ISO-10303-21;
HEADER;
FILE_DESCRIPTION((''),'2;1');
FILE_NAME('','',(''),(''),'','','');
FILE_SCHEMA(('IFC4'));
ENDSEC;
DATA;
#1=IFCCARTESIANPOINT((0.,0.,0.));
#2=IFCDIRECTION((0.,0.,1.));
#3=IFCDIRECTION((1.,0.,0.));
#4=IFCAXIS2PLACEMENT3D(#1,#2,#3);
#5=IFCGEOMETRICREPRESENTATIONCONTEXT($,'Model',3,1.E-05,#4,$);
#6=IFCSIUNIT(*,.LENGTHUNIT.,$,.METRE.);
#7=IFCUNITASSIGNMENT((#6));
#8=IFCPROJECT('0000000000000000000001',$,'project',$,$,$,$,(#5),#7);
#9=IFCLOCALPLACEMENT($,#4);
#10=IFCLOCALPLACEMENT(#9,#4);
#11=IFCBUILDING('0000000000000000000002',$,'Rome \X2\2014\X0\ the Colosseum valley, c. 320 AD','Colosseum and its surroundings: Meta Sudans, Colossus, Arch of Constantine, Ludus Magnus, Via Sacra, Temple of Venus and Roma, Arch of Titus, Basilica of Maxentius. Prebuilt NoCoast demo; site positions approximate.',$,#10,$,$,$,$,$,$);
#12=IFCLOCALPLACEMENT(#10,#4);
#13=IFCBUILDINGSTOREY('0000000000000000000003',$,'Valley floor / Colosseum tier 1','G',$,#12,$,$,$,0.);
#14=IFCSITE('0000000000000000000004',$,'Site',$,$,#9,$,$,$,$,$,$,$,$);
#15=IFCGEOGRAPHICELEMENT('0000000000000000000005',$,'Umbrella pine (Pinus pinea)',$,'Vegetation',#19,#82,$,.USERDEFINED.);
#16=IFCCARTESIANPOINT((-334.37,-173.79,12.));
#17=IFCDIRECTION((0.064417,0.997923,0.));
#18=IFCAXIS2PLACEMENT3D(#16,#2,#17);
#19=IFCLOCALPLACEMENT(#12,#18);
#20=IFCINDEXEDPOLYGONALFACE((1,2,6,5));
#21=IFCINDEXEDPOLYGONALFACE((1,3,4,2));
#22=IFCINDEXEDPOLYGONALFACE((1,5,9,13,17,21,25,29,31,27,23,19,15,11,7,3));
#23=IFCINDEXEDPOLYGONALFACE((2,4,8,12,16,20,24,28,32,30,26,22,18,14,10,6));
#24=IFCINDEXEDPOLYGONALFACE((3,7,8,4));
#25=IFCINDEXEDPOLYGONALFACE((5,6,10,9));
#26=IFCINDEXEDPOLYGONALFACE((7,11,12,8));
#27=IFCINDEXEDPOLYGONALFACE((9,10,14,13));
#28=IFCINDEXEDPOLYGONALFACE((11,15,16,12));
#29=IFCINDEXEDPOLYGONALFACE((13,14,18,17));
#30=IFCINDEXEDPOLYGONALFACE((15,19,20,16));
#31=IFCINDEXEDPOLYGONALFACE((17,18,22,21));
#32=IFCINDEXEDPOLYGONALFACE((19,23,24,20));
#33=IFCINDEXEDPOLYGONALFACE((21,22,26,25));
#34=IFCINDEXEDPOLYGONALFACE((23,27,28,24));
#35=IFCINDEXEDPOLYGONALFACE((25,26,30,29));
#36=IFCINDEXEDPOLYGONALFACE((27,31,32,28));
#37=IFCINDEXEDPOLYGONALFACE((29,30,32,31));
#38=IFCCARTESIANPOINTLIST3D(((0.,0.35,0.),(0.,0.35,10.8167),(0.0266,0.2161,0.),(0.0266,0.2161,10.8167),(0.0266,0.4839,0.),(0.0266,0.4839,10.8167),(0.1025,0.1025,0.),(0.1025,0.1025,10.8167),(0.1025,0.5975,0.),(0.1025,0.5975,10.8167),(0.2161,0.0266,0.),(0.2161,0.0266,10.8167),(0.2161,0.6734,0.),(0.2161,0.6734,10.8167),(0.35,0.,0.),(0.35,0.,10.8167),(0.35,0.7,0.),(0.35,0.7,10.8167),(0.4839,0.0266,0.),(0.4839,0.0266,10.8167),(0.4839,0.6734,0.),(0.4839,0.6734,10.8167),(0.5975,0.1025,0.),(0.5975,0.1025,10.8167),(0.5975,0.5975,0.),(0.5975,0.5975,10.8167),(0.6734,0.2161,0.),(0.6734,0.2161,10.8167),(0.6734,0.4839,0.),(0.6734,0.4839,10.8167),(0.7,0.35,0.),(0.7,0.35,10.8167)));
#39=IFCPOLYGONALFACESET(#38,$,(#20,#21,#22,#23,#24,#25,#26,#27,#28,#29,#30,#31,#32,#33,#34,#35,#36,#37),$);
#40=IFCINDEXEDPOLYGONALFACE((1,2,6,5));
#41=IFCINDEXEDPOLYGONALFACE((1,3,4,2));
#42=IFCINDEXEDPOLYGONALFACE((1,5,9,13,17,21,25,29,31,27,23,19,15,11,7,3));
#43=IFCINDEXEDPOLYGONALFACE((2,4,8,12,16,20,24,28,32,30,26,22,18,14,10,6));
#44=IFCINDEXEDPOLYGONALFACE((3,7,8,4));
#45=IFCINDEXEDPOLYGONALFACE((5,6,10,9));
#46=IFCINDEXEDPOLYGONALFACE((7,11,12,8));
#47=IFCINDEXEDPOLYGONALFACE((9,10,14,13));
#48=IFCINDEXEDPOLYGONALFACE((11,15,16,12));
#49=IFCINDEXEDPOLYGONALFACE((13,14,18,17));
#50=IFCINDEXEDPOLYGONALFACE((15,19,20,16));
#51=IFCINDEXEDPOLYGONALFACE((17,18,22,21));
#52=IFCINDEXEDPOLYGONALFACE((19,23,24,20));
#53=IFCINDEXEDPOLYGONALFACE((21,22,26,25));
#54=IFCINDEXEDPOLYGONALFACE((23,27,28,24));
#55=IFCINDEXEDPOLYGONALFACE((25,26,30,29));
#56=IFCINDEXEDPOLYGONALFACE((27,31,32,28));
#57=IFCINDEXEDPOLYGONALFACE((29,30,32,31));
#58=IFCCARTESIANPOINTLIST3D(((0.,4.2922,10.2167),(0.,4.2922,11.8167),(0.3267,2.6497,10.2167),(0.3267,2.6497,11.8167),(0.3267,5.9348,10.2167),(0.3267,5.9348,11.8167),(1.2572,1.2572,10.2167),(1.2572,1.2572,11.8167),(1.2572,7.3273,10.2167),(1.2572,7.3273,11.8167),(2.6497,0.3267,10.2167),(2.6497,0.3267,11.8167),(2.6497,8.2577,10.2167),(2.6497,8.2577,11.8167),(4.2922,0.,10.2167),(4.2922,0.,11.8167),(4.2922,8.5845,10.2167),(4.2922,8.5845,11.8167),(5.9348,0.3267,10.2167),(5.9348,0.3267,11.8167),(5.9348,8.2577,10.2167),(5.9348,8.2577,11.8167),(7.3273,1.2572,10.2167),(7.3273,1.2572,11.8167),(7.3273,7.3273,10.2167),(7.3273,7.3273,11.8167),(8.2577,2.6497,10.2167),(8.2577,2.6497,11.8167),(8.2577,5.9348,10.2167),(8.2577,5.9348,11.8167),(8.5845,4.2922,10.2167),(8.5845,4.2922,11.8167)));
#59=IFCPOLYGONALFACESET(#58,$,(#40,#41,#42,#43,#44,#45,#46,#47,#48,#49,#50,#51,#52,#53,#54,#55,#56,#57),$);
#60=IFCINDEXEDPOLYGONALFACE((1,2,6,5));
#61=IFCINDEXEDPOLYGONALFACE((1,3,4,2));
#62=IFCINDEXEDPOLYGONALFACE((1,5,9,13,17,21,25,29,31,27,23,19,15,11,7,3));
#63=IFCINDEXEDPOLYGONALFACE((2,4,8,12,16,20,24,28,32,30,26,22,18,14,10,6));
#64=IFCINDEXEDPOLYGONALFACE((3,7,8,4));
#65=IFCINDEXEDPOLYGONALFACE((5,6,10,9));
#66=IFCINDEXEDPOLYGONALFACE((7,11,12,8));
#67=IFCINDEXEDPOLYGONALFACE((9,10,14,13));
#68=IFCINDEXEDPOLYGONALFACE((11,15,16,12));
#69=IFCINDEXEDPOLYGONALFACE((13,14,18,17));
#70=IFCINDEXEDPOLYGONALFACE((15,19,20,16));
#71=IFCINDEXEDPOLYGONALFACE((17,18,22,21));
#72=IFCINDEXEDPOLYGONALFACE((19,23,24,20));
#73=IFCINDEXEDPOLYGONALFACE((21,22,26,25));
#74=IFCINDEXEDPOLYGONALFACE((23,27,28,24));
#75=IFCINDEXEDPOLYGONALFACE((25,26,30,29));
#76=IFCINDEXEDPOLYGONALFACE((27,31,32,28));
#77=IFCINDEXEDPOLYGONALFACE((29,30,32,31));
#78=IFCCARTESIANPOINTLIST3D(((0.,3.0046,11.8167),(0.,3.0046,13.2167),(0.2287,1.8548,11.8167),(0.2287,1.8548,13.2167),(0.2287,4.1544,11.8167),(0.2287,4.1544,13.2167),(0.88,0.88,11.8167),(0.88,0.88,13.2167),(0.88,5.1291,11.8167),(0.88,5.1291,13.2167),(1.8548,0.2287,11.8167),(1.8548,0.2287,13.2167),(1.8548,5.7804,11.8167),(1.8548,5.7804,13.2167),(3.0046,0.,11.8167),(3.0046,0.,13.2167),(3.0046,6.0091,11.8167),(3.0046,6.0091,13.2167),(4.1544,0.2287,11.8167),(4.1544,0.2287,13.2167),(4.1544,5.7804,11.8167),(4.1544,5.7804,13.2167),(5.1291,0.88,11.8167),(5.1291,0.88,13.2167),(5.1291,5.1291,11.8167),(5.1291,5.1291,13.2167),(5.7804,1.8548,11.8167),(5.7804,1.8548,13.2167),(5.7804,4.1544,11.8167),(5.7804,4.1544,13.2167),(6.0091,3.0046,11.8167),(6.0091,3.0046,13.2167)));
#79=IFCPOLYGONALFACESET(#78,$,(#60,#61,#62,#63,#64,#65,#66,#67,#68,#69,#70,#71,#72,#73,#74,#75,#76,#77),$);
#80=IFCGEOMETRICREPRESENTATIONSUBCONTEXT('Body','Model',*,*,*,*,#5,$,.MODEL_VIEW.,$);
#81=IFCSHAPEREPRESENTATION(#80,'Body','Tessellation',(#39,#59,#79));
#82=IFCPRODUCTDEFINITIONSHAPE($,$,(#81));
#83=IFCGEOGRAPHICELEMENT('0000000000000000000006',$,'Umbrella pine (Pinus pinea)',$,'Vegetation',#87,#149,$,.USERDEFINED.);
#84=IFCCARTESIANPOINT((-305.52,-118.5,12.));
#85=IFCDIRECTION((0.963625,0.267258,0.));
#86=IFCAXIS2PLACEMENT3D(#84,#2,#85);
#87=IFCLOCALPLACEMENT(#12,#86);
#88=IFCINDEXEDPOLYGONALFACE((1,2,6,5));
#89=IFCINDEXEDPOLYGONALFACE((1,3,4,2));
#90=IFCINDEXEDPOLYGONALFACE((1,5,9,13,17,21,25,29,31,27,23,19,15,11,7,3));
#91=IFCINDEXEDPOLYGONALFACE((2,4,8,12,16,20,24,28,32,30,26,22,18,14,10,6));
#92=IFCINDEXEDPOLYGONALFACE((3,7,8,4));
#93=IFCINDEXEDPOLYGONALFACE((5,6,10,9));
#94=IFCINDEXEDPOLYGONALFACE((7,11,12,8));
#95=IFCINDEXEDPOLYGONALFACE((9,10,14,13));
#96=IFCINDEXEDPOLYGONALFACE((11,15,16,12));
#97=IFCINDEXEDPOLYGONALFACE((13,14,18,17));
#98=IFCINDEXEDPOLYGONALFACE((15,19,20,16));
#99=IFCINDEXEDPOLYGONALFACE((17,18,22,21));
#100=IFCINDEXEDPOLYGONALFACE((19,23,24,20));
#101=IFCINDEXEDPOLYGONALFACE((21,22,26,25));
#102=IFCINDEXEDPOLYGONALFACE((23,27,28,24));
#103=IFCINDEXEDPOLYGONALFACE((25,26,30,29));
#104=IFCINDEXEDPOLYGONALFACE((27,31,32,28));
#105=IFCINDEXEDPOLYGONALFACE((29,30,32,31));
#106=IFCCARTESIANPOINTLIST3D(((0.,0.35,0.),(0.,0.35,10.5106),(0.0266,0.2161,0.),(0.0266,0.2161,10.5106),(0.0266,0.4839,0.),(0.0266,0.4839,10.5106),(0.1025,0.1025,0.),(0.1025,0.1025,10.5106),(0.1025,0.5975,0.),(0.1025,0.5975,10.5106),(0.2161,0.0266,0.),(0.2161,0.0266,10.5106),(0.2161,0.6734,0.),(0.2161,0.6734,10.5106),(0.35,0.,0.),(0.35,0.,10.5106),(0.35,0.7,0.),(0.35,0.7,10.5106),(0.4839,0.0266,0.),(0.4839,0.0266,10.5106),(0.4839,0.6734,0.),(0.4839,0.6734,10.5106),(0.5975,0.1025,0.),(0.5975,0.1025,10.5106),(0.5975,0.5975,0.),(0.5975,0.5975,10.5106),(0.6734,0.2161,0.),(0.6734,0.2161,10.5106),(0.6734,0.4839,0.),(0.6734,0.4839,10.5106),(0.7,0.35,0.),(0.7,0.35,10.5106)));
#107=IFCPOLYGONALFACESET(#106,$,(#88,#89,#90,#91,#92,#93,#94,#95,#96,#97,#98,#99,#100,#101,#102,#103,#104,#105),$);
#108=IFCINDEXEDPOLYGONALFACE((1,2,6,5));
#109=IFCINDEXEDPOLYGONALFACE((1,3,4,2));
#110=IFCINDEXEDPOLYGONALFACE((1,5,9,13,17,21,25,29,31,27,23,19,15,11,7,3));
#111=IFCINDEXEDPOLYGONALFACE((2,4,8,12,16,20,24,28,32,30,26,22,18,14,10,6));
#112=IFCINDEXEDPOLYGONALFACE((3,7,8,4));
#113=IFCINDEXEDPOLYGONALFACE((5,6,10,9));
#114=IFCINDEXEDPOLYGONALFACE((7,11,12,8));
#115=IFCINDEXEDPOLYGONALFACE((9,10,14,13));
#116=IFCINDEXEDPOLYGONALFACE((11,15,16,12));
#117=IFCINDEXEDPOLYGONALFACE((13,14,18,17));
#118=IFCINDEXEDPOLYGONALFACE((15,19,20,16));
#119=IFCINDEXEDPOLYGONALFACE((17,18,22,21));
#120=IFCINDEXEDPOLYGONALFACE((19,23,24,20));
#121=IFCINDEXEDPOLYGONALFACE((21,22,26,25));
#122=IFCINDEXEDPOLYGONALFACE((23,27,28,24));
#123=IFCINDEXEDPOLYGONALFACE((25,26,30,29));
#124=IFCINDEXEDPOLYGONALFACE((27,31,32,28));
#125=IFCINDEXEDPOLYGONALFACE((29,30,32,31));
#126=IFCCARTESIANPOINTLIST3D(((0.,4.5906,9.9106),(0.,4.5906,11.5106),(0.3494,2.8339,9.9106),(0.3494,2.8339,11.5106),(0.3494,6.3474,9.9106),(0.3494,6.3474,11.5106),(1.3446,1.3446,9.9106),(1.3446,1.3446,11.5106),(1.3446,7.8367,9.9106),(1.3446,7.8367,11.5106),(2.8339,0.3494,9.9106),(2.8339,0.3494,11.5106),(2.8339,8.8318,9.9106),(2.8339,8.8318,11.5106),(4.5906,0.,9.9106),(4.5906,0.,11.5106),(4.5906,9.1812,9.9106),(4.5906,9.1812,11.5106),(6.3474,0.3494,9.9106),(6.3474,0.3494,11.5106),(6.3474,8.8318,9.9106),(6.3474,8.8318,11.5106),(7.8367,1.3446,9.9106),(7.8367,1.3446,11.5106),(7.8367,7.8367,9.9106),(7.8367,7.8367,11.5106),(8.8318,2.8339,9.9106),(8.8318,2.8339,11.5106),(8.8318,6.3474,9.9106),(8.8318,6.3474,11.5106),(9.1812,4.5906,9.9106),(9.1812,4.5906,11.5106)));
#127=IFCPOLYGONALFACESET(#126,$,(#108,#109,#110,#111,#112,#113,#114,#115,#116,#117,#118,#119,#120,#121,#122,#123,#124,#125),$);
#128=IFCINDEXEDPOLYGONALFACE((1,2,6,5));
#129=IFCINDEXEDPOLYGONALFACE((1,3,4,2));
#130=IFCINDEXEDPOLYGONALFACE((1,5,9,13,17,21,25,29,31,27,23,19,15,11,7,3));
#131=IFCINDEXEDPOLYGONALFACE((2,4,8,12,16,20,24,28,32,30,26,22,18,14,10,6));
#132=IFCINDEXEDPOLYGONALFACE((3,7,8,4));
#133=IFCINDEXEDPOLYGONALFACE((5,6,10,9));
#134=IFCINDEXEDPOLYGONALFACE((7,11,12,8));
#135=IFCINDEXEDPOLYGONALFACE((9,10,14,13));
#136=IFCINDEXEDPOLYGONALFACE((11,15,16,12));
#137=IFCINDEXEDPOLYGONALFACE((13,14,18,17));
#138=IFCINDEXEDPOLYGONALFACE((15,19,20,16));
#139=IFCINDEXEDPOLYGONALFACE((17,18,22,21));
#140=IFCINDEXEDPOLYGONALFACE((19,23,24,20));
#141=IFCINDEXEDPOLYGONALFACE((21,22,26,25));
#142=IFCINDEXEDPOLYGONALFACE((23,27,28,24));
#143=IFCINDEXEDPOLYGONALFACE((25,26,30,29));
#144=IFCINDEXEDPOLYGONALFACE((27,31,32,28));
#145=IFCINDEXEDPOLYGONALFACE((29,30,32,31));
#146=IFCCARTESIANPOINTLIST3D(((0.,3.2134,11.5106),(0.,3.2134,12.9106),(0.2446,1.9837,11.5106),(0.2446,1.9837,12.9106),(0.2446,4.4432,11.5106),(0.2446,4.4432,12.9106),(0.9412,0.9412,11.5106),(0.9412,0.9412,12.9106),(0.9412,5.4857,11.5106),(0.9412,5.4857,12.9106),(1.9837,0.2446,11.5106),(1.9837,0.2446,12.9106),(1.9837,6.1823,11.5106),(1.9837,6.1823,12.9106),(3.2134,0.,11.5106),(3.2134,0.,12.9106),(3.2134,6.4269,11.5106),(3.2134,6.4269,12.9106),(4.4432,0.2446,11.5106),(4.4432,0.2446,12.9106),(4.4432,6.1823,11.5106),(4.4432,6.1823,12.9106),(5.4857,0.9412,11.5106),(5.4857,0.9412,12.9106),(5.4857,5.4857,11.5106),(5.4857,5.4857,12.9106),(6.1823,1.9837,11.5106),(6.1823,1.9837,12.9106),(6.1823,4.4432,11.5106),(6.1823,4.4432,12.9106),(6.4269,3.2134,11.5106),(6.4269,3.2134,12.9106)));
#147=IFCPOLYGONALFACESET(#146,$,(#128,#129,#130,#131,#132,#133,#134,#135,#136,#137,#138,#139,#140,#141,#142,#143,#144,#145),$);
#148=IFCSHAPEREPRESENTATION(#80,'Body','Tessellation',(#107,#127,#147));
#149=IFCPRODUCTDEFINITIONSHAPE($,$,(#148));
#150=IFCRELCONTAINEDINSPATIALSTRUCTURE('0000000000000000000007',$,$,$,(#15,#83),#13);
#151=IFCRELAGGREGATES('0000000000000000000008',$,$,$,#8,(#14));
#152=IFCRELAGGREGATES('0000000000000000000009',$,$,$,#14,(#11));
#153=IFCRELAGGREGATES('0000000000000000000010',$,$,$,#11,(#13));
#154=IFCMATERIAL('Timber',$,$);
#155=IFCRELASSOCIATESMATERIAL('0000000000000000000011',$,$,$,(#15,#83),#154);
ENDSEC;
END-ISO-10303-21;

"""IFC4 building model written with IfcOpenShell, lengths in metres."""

from ifc_helpers import new_model, si_unit, frame, origin_with_axes, place, context, subcontext, project, spatial, polyline, outline, extrude, material, element, save


model = new_model("IFC4")

# Units and contexts
model_context = context("Model", 3, precision=1e-05, world=origin_with_axes())
body_context = subcontext(model_context, "Body", "Model", "MODEL_VIEW")
ifc_project = project(units=[si_unit("LENGTHUNIT", "METRE")], contexts=[model_context])

# Site, building, storey
site_placement = place(None, origin_with_axes())
site = spatial("IfcSite", under=ifc_project, at=site_placement, Name="Site")
building_placement = place(site_placement, origin_with_axes())
building = spatial("IfcBuilding", under=site, at=building_placement, Name="Rome — the Colosseum valley, c. 320 AD", Description="Colosseum and its surroundings: Meta Sudans, Colossus, Arch of Constantine, Ludus Magnus, Via Sacra, Temple of Venus and Roma, Arch of Titus, Basilica of Maxentius. Prebuilt NoCoast demo; site positions approximate.")
storey_placement = place(building_placement, origin_with_axes())
storey = spatial("IfcBuildingStorey", under=building, at=storey_placement, Name="Valley floor / Colosseum tier 1", Description="G", Elevation=0.0)

# Shared definitions
ifc_material_1 = material(Name="Timber")

# Geographic elements
geographic_element_1_placement = place(storey_placement, frame((-334.37, -173.79, 12.0), z_axis=(0.0, 0.0, 1.0), x_axis=(0.064417, 0.997923, 0.0)))
element("IfcGeographicElement", 1, at=geographic_element_1_placement, inside=storey, material=ifc_material_1, Name="Umbrella pine (Pinus pinea)", ObjectType="Vegetation", PredefinedType="USERDEFINED", context=body_context, shape_type="SweptSolid", body=[
    extrude(outline(polyline([(0.7, 0.35), (0.6734, 0.4839), (0.5975, 0.5975), (0.4839, 0.6734), (0.35, 0.7), (0.2161, 0.6734), (0.1025, 0.5975), (0.0266, 0.4839), (0.0, 0.35), (0.0266, 0.2161), (0.1025, 0.1025), (0.2161, 0.0266), (0.35, 0.0), (0.4839, 0.0266), (0.5975, 0.1025), (0.6734, 0.2161), (0.7, 0.35)])), origin_with_axes(), (0.0, 0.0, 1.0), 10.8167),
    extrude(outline(polyline([(8.5845, 4.2922), (8.2577, 5.9348), (7.3273, 7.3273), (5.9348, 8.2577), (4.2922, 8.5845), (2.6497, 8.2577), (1.2572, 7.3273), (0.3267, 5.9348), (0.0, 4.2922), (0.3267, 2.6497), (1.2572, 1.2572), (2.6497, 0.3267), (4.2922, 0.0), (5.9348, 0.3267), (7.3273, 1.2572), (8.2577, 2.6497), (8.5845, 4.2922)])), frame((0.0, 0.0, 10.2167), z_axis=(0.0, 0.0, 1.0), x_axis=(1.0, 0.0, 0.0)), (0.0, 0.0, 1.0), 1.6),
    extrude(outline(polyline([(6.0091, 3.0046), (5.7804, 4.1544), (5.1291, 5.1291), (4.1544, 5.7804), (3.0046, 6.0091), (1.8548, 5.7804), (0.88, 5.1291), (0.2287, 4.1544), (0.0, 3.0046), (0.2287, 1.8548), (0.88, 0.88), (1.8548, 0.2287), (3.0046, 0.0), (4.1544, 0.2287), (5.1291, 0.88), (5.7804, 1.8548), (6.0091, 3.0046)])), frame((0.0, 0.0, 11.8167), z_axis=(0.0, 0.0, 1.0), x_axis=(1.0, 0.0, 0.0)), (0.0, 0.0, 1.0), 1.4),
])
geographic_element_2_placement = place(storey_placement, frame((-305.52, -118.5, 12.0), z_axis=(0.0, 0.0, 1.0), x_axis=(0.963625, 0.267258, 0.0)))
element("IfcGeographicElement", 2, at=geographic_element_2_placement, inside=storey, material=ifc_material_1, Name="Umbrella pine (Pinus pinea)", ObjectType="Vegetation", PredefinedType="USERDEFINED", context=body_context, shape_type="SweptSolid", body=[
    extrude(outline(polyline([(0.7, 0.35), (0.6734, 0.4839), (0.5975, 0.5975), (0.4839, 0.6734), (0.35, 0.7), (0.2161, 0.6734), (0.1025, 0.5975), (0.0266, 0.4839), (0.0, 0.35), (0.0266, 0.2161), (0.1025, 0.1025), (0.2161, 0.0266), (0.35, 0.0), (0.4839, 0.0266), (0.5975, 0.1025), (0.6734, 0.2161), (0.7, 0.35)])), origin_with_axes(), (0.0, 0.0, 1.0), 10.5106),
    extrude(outline(polyline([(9.1812, 4.5906), (8.8318, 6.3474), (7.8367, 7.8367), (6.3474, 8.8318), (4.5906, 9.1812), (2.8339, 8.8318), (1.3446, 7.8367), (0.3494, 6.3474), (0.0, 4.5906), (0.3494, 2.8339), (1.3446, 1.3446), (2.8339, 0.3494), (4.5906, 0.0), (6.3474, 0.3494), (7.8367, 1.3446), (8.8318, 2.8339), (9.1812, 4.5906)])), frame((0.0, 0.0, 9.9106), z_axis=(0.0, 0.0, 1.0), x_axis=(1.0, 0.0, 0.0)), (0.0, 0.0, 1.0), 1.6),
    extrude(outline(polyline([(6.4269, 3.2134), (6.1823, 4.4432), (5.4857, 5.4857), (4.4432, 6.1823), (3.2134, 6.4269), (1.9837, 6.1823), (0.9412, 5.4857), (0.2446, 4.4432), (0.0, 3.2134), (0.2446, 1.9837), (0.9412, 0.9412), (1.9837, 0.2446), (3.2134, 0.0), (4.4432, 0.2446), (5.4857, 0.9412), (6.1823, 1.9837), (6.4269, 3.2134)])), frame((0.0, 0.0, 11.5106), z_axis=(0.0, 0.0, 1.0), x_axis=(1.0, 0.0, 0.0)), (0.0, 0.0, 1.0), 1.4),
])

save(model, "model.ifc")
